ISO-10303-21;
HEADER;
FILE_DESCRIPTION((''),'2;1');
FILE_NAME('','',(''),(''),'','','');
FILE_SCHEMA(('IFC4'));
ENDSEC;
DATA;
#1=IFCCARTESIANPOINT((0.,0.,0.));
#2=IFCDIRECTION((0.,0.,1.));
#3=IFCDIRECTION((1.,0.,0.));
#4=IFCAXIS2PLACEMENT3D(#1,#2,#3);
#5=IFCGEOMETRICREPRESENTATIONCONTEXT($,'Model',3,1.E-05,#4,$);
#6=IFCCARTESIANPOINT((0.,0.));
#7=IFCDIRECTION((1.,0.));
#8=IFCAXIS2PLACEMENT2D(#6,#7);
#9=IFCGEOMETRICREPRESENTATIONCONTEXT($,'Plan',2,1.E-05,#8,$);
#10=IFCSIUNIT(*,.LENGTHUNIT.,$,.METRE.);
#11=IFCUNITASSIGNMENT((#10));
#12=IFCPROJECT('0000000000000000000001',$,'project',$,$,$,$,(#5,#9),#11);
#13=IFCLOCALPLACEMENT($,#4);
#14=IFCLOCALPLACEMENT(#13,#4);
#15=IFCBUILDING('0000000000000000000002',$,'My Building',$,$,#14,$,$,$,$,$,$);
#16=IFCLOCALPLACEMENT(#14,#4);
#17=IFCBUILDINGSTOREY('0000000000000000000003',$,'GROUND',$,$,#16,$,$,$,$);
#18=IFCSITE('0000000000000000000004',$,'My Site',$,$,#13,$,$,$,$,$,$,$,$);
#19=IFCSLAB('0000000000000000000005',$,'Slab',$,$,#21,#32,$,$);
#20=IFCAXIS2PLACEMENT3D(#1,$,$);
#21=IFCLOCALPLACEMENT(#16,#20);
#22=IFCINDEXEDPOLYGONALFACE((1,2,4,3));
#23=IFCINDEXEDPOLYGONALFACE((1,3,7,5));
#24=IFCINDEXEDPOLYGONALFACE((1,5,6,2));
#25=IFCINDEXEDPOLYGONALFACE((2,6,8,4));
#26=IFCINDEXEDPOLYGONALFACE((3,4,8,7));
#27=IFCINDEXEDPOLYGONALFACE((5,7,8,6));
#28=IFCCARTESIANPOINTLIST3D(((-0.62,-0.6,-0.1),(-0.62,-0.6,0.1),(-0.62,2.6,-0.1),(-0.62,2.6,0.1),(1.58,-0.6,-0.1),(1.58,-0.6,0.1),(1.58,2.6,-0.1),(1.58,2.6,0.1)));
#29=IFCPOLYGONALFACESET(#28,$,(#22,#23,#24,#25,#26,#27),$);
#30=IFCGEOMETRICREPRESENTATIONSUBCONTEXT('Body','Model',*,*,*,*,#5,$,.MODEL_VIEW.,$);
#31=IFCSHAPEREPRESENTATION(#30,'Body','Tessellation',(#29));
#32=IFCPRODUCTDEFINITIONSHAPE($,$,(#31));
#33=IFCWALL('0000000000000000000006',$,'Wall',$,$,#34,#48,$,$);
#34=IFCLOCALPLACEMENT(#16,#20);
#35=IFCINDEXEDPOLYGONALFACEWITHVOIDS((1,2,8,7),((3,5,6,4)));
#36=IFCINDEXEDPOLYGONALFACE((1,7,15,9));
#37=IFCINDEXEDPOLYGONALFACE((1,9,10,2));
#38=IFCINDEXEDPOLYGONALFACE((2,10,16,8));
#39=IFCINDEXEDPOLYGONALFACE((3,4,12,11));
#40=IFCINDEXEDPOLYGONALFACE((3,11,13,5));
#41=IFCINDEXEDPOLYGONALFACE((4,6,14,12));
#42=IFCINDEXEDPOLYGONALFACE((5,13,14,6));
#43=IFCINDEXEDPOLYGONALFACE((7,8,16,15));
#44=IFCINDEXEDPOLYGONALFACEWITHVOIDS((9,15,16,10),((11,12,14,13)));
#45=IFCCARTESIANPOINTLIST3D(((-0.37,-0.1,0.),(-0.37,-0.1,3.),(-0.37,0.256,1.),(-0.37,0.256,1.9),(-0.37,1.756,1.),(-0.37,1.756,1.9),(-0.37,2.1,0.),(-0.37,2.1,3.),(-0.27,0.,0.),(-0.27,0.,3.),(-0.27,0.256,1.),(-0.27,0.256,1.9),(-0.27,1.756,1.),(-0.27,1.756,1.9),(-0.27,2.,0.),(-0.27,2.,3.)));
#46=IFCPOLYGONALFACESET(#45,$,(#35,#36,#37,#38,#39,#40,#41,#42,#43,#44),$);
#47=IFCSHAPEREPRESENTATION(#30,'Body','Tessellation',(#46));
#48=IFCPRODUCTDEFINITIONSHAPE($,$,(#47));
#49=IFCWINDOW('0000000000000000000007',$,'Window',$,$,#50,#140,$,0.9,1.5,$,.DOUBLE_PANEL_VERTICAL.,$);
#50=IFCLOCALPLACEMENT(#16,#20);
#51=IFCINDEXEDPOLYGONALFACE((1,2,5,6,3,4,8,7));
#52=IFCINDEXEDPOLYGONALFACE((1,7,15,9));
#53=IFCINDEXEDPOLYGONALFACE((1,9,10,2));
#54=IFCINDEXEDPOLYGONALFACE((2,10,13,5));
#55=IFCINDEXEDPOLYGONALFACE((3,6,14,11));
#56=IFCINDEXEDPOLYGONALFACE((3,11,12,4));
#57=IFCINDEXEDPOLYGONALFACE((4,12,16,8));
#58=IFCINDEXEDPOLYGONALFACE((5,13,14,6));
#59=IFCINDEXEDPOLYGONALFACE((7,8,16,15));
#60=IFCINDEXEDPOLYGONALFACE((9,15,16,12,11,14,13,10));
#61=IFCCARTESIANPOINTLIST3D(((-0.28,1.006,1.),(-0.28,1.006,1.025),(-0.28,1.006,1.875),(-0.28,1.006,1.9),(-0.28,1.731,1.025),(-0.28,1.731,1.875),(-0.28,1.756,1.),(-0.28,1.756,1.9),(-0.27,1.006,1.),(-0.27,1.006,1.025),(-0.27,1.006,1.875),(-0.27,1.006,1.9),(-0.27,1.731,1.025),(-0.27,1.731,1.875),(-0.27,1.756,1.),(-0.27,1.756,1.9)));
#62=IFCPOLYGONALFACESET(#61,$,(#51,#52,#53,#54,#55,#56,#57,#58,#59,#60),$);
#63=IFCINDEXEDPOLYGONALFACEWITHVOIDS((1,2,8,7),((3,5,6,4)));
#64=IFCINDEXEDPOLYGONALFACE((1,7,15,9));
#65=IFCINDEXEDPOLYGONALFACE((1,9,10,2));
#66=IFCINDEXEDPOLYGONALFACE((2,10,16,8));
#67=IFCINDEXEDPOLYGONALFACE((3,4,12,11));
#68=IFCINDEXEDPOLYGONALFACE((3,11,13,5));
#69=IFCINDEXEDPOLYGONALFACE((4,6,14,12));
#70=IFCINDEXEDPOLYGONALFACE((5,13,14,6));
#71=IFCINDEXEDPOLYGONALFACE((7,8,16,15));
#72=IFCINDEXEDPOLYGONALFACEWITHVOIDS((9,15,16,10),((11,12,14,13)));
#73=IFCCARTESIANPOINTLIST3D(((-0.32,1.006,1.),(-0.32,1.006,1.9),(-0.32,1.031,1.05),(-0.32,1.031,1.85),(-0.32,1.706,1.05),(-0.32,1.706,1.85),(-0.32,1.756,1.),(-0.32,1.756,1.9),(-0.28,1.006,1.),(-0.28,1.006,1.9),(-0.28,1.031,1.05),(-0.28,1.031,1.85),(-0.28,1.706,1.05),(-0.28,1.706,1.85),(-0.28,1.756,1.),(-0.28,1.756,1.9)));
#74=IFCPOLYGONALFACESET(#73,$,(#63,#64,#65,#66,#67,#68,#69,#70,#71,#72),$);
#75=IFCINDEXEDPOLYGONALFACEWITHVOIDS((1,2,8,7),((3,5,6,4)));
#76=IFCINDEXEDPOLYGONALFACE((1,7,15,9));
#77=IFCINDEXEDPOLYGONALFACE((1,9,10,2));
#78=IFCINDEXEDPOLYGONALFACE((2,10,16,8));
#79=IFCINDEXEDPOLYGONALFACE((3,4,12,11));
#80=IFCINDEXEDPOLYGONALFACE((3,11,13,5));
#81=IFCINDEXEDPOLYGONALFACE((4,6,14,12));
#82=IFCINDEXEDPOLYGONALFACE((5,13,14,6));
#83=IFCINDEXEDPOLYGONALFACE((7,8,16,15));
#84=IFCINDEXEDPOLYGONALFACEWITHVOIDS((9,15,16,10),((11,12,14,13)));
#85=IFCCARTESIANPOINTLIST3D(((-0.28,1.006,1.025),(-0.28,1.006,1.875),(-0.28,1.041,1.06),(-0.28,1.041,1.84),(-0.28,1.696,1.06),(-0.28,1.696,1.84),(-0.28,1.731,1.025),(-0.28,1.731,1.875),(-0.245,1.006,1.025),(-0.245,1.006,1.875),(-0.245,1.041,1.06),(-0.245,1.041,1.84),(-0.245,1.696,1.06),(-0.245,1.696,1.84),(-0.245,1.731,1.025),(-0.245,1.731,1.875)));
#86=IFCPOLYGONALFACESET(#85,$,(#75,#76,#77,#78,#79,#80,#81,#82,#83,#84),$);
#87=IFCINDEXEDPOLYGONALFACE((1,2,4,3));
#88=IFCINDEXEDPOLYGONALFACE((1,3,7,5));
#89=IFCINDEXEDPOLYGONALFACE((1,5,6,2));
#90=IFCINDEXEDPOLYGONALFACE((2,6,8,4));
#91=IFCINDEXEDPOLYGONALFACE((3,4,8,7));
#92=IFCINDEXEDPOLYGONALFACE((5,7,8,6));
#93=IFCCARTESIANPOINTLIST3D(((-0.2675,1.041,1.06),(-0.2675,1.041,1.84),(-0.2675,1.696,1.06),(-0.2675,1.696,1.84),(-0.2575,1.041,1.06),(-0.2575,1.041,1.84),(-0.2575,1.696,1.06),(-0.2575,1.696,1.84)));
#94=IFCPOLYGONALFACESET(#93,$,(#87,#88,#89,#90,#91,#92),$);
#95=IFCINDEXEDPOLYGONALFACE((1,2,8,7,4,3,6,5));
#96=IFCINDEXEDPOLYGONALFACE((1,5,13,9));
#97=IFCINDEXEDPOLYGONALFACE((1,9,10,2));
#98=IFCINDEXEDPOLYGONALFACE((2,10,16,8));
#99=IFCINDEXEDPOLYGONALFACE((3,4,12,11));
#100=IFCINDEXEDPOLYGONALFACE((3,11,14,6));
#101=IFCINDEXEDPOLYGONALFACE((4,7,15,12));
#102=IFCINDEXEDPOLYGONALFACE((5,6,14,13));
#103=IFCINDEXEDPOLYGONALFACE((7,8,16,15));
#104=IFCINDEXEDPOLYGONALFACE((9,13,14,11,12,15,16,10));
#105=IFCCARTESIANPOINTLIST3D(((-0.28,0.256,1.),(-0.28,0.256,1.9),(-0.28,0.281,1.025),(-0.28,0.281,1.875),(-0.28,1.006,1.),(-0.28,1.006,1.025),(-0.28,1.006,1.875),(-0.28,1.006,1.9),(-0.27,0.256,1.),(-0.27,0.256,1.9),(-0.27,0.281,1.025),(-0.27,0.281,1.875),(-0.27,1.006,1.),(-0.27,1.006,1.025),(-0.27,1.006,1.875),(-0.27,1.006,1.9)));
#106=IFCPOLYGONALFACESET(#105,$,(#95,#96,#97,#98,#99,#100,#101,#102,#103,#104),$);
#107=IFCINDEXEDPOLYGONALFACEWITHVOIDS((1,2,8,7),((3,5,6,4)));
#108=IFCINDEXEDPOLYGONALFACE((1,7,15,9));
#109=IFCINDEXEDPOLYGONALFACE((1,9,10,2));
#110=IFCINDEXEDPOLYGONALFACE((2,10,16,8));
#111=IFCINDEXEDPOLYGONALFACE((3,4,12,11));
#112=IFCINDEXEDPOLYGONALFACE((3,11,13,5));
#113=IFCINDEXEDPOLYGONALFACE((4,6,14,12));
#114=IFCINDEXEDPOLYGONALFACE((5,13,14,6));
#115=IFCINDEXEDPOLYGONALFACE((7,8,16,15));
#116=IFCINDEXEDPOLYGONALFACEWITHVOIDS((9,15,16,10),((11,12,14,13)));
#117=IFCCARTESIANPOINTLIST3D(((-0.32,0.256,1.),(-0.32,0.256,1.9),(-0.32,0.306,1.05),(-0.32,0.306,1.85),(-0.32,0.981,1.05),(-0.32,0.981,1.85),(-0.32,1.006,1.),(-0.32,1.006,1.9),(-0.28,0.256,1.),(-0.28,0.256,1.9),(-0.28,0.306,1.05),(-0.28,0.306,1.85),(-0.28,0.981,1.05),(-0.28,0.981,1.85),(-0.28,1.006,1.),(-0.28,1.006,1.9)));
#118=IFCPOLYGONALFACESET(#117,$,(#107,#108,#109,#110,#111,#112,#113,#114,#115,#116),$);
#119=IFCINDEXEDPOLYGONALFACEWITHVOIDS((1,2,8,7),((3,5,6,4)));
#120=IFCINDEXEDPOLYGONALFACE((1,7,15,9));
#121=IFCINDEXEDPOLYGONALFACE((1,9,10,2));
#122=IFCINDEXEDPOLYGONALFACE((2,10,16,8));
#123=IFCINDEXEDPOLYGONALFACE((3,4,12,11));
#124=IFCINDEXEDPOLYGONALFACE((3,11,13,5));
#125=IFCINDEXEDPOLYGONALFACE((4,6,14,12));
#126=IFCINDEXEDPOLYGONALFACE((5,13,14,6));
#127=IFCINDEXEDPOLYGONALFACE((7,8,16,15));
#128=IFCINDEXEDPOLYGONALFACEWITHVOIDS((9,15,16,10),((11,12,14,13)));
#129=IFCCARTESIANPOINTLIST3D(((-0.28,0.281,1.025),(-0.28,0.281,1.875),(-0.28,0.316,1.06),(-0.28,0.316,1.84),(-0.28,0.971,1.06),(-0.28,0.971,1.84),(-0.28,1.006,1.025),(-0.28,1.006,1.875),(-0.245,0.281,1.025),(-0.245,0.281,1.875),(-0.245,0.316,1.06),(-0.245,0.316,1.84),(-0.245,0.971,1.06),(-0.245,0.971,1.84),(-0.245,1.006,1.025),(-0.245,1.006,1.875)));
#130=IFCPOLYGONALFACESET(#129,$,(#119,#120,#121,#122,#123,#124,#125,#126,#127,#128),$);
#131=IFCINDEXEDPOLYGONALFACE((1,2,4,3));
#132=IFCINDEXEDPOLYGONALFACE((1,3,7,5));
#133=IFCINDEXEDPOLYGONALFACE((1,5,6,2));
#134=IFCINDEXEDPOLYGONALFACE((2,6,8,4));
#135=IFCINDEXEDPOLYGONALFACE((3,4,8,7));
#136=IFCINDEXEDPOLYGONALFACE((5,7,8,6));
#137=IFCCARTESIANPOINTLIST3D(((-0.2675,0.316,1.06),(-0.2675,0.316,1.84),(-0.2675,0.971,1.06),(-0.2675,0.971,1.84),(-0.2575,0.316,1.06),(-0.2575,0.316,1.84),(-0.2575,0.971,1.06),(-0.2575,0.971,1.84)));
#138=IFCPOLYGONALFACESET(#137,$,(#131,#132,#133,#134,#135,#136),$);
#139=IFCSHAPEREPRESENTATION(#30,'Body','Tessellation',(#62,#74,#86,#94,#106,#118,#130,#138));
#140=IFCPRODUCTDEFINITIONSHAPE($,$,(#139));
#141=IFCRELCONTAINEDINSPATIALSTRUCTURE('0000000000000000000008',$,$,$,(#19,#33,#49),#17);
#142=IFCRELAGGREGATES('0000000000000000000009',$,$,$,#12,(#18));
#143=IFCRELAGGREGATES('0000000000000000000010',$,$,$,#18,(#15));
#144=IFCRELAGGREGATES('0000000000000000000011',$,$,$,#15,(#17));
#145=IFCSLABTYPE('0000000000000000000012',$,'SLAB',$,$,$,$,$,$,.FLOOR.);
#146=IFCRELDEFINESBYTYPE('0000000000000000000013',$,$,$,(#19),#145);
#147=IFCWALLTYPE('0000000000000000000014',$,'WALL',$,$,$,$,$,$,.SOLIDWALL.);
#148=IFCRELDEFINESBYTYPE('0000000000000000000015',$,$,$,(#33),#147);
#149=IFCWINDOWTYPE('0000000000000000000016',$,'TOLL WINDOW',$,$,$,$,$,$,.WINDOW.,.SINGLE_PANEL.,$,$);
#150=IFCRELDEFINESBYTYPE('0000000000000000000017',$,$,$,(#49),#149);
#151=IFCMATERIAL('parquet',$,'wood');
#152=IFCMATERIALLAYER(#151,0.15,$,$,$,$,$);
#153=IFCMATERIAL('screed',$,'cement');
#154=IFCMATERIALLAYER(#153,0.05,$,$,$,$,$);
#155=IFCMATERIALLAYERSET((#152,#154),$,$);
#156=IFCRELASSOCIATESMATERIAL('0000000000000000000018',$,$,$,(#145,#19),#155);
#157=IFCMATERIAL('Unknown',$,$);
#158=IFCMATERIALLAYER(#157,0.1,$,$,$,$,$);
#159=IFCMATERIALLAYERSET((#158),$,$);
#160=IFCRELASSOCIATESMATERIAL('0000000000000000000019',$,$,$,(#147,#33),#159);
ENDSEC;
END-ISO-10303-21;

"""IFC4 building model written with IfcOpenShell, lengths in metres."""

from ifc_helpers import new_model, entity, si_unit, frame, origin_with_axes, origin_2d_with_axis, place, context, subcontext, project, spatial, line, indexed_curve, outline, extrude, shape, source, transform, mapped, material, layer, layer_set, layer_usage, type_object, type_shapes, element, fill, save


model = new_model("IFC4")

# Units and contexts
model_context = context("Model", 3, precision=1e-05, world=origin_with_axes())
plan_context = context("Plan", 2, precision=1e-05, world=origin_2d_with_axis())
body_context_1 = subcontext(model_context, "Body", "Model", "MODEL_VIEW")
body_context_2 = subcontext(plan_context, "Body", "Plan", "PLAN_VIEW")
ifc_project = project(units=[si_unit("LENGTHUNIT", "METRE")], contexts=[model_context, plan_context])

# Site, building, storey
site_placement = place(None, origin_with_axes())
site = spatial("IfcSite", under=ifc_project, at=site_placement, Name="My Site")
building_placement = place(site_placement, origin_with_axes())
building = spatial("IfcBuilding", under=site, at=building_placement, Name="My Building")
storey_placement = place(building_placement, origin_with_axes())
storey = spatial("IfcBuildingStorey", under=building, at=storey_placement, Name="GROUND")

# Slab
ifc_material_1 = material(Name="parquet", Category="wood")
ifc_layer_1 = layer(ifc_material_1, 0.15)
ifc_material_2 = material(Name="screed", Category="cement")
ifc_layer_2 = layer(ifc_material_2, 0.05)
ifc_layer_set_1 = layer_set([ifc_layer_1, ifc_layer_2])
ifc_layer_usage_1 = layer_usage(ifc_layer_set_1, "AXIS3", "POSITIVE", -0.1)
slab_type = type_object("IfcSlabType", Name="SLAB", PredefinedType="FLOOR", material=ifc_layer_set_1)
slab_placement = place(storey_placement, frame((-0.62, 2.6, 0.0), z_axis=(0.0, 0.0, 1.0), x_axis=(1.0, 0.0, 0.0)))
element("IfcSlab", 1, at=slab_placement, inside=storey, type_object=slab_type, material=ifc_layer_usage_1, Name="Slab", context=body_context_1, shape_type="SweptSolid", body=[
    extrude(outline(indexed_curve([(0.0, 0.0), (2.2, 0.0), (2.2, -3.2), (0.0, -3.2), (0.0, 0.0)])), frame((0.0, 0.0, -0.1), z_axis=(0.0, 0.0, 1.0), x_axis=(1.0, 0.0, 0.0)), (0.0, 0.0, 1.0), 0.2),
])

# Wall, opening, window
ifc_material_3 = material(Name="Unknown")
ifc_layer_3 = layer(ifc_material_3, 0.1)
ifc_layer_set_2 = layer_set([ifc_layer_3])
ifc_layer_usage_2 = layer_usage(ifc_layer_set_2, "AXIS2", "POSITIVE", 0.0)
wall_type = type_object("IfcWallType", Name="WALL", PredefinedType="SOLIDWALL", material=ifc_layer_set_2)
wall_1_placement = place(storey_placement, frame((-0.27, 0.0, 0.0), z_axis=(0.0, 0.0, 1.0), x_axis=(0.0, 1.0, 0.0)))
wall_1 = element("IfcWall", 2, at=wall_1_placement, inside=storey, type_object=wall_type, material=ifc_layer_usage_2, Name="Wall", context=body_context_1, shape_type="SweptSolid", body=[
    extrude(outline(indexed_curve([(0.0, 0.0), (-0.1, 0.1), (2.1, 0.1), (2.0, 0.0)], segments=[line(1, 2, 3, 4, 1)])), origin_with_axes(), (0.0, 0.0, 1.0), 3.0),
])
shared_shape_1 = source(origin_with_axes(), body_context_1, "Body", "SweptSolid", [
    extrude(outline(indexed_curve([(0.0, 0.0), (1.5, 0.0), (1.5, 0.9), (0.0, 0.9)], segments=[line(1, 2, 3, 4, 1)])), frame((0.0, -0.6, 0.0), z_axis=(0.0, -1.0, 0.0), x_axis=(1.0, 0.0, 0.0)), (0.0, 0.0, -1.0), 1.2),
])
opening_1_placement = place(wall_1_placement, frame((1.756, 0.1, 1.0), z_axis=(0.0, 0.0, 1.0), x_axis=(-1.0, 0.0, 0.0)))
opening_1 = element("IfcOpeningElement", 3, at=opening_1_placement, cuts=wall_1, PredefinedType="OPENING", context=body_context_1, shape_type="MappedRepresentation", body=[
    mapped(shared_shape_1, transform((0.0, 0.0, 0.0), x_axis=(1.0, 0.0, 0.0), y_axis=(0.0, 1.0, 0.0), z_axis=(0.0, 0.0, 1.0), scale=1.0)),
])
window_type_1 = type_object("IfcWindowType", Name="TOLL WINDOW", PartitioningType="SINGLE_PANEL", PredefinedType="WINDOW")
shared_shape_2 = source(origin_with_axes(), body_context_1, "Body", "SweptSolid", [
    extrude(outline(indexed_curve([(0.75, 0.0), (0.0, 0.0), (0.0, 0.9), (0.75, 0.9), (0.75, 0.875), (0.025, 0.875), (0.025, 0.025), (0.75, 0.025)], segments=[line(1, 2, 3, 4, 5, 6, 7, 8, 1)])), frame((0.0, 0.09, 0.0), z_axis=(0.0, -1.0, 0.0), x_axis=(1.0, 0.0, 0.0)), (0.0, 0.0, -1.0), 0.01),
    extrude(outline(indexed_curve([(0.0, 0.0), (0.75, 0.0), (0.75, 0.9), (0.0, 0.9)], segments=[line(1, 2, 3, 4, 1)]), holes=[indexed_curve([(0.05, 0.05), (0.725, 0.05), (0.725, 0.85), (0.05, 0.85)], segments=[line(1, 2, 3, 4, 1)])]), frame((0.0, 0.05, 0.0), z_axis=(0.0, -1.0, 0.0), x_axis=(1.0, 0.0, 0.0)), (0.0, 0.0, -1.0), 0.04),
    extrude(outline(indexed_curve([(0.0, 0.0), (0.725, 0.0), (0.725, 0.85), (0.0, 0.85)], segments=[line(1, 2, 3, 4, 1)]), holes=[indexed_curve([(0.035, 0.035), (0.69, 0.035), (0.69, 0.815), (0.035, 0.815)], segments=[line(1, 2, 3, 4, 1)])]), frame((0.025, 0.09, 0.025), z_axis=(0.0, -1.0, 0.0), x_axis=(1.0, 0.0, 0.0)), (0.0, 0.0, -1.0), 0.035),
    extrude(outline(indexed_curve([(0.035, 0.035), (0.69, 0.035), (0.69, 0.815), (0.035, 0.815)], segments=[line(1, 2, 3, 4, 1)])), frame((0.025, 0.1025, 0.025), z_axis=(0.0, -1.0, 0.0), x_axis=(1.0, 0.0, 0.0)), (0.0, 0.0, -1.0), 0.01),
    extrude(outline(indexed_curve([(0.0, 0.9), (0.75, 0.9), (0.75, 0.0), (0.0, 0.0), (0.0, 0.025), (0.725, 0.025), (0.725, 0.875), (0.0, 0.875)], segments=[line(1, 2, 3, 4, 5, 6, 7, 8, 1)])), frame((0.75, 0.09, 0.0), z_axis=(0.0, -1.0, 0.0), x_axis=(1.0, 0.0, 0.0)), (0.0, 0.0, -1.0), 0.01),
    extrude(outline(indexed_curve([(0.0, 0.0), (0.75, 0.0), (0.75, 0.9), (0.0, 0.9)], segments=[line(1, 2, 3, 4, 1)]), holes=[indexed_curve([(0.025, 0.05), (0.7, 0.05), (0.7, 0.85), (0.025, 0.85)], segments=[line(1, 2, 3, 4, 1)])]), frame((0.75, 0.05, 0.0), z_axis=(0.0, -1.0, 0.0), x_axis=(1.0, 0.0, 0.0)), (0.0, 0.0, -1.0), 0.04),
    extrude(outline(indexed_curve([(0.0, 0.0), (0.725, 0.0), (0.725, 0.85), (0.0, 0.85)], segments=[line(1, 2, 3, 4, 1)]), holes=[indexed_curve([(0.035, 0.035), (0.69, 0.035), (0.69, 0.815), (0.035, 0.815)], segments=[line(1, 2, 3, 4, 1)])]), frame((0.75, 0.09, 0.025), z_axis=(0.0, -1.0, 0.0), x_axis=(1.0, 0.0, 0.0)), (0.0, 0.0, -1.0), 0.035),
    extrude(outline(indexed_curve([(0.035, 0.035), (0.69, 0.035), (0.69, 0.815), (0.035, 0.815)], segments=[line(1, 2, 3, 4, 1)])), frame((0.75, 0.1025, 0.025), z_axis=(0.0, -1.0, 0.0), x_axis=(1.0, 0.0, 0.0)), (0.0, 0.0, -1.0), 0.01),
])
shared_shape_3 = source(origin_with_axes(), body_context_2, "Body", "Curve2D", [
    entity("IfcIndexedPolyCurve", entity("IfcCartesianPointList2D", [[0.05, 0.05], [0.725, 0.05]])),
    entity("IfcIndexedPolyCurve", entity("IfcCartesianPointList2D", [[0.0, 0.1], [0.025, 0.1], [0.025, 0.09], [0.05, 0.09], [0.05, 0.05], [0.0, 0.05]]), [entity("IfcLineIndex", [1, 2, 3, 4, 5, 6, 1])]),
    entity("IfcIndexedPolyCurve", entity("IfcCartesianPointList2D", [[0.75, 0.1], [0.75, 0.1], [0.75, 0.09], [0.725, 0.09], [0.725, 0.05], [0.75, 0.05]])),
    entity("IfcIndexedPolyCurve", entity("IfcCartesianPointList2D", [[0.025, 0.09], [0.06, 0.09], [0.06, 0.125], [0.025, 0.125]]), [entity("IfcLineIndex", [1, 2, 3, 4, 1])]),
    entity("IfcIndexedPolyCurve", entity("IfcCartesianPointList2D", [[0.75, 0.09], [0.715, 0.09], [0.715, 0.125], [0.75, 0.125]]), [entity("IfcLineIndex", [1, 2, 3, 4, 1])]),
    entity("IfcIndexedPolyCurve", entity("IfcCartesianPointList2D", [[0.06, 0.09], [0.715, 0.09]])),
    entity("IfcIndexedPolyCurve", entity("IfcCartesianPointList2D", [[0.06, 0.125], [0.715, 0.125]])),
    entity("IfcIndexedPolyCurve", entity("IfcCartesianPointList2D", [[0.06, 0.1075], [0.715, 0.1075]])),
    entity("IfcIndexedPolyCurve", entity("IfcCartesianPointList2D", [[0.775, 0.05], [1.45, 0.05]])),
    entity("IfcIndexedPolyCurve", entity("IfcCartesianPointList2D", [[0.75, 0.1], [0.75, 0.1], [0.75, 0.09], [0.775, 0.09], [0.775, 0.05], [0.75, 0.05]])),
    entity("IfcIndexedPolyCurve", entity("IfcCartesianPointList2D", [[1.5, 0.1], [1.475, 0.1], [1.475, 0.09], [1.45, 0.09], [1.45, 0.05], [1.5, 0.05]]), [entity("IfcLineIndex", [1, 2, 3, 4, 5, 6, 1])]),
    entity("IfcIndexedPolyCurve", entity("IfcCartesianPointList2D", [[0.75, 0.09], [0.785, 0.09], [0.785, 0.125], [0.75, 0.125]]), [entity("IfcLineIndex", [1, 2, 3, 4, 1])]),
    entity("IfcIndexedPolyCurve", entity("IfcCartesianPointList2D", [[1.475, 0.09], [1.44, 0.09], [1.44, 0.125], [1.475, 0.125]]), [entity("IfcLineIndex", [1, 2, 3, 4, 1])]),
    entity("IfcIndexedPolyCurve", entity("IfcCartesianPointList2D", [[0.785, 0.09], [1.44, 0.09]])),
    entity("IfcIndexedPolyCurve", entity("IfcCartesianPointList2D", [[0.785, 0.125], [1.44, 0.125]])),
    entity("IfcIndexedPolyCurve", entity("IfcCartesianPointList2D", [[0.785, 0.1075], [1.44, 0.1075]])),
])
type_shapes(window_type_1, [shared_shape_2, shared_shape_3])
window_1_placement = place(opening_1_placement, frame((0.0, 0.0, 0.0), z_axis=(0.0, 0.0, 1.0), x_axis=(1.0, 0.0, 0.0)))
window_1 = element("IfcWindow", 4, at=window_1_placement, inside=storey, type_object=window_type_1, Name="Window", OverallHeight=0.9, OverallWidth=1.5, PartitioningType="DOUBLE_PANEL_VERTICAL", shapes=[
    shape(body_context_1, "Body", "MappedRepresentation", [mapped(shared_shape_2, transform((0.0, 0.0, 0.0), x_axis=(1.0, 0.0, 0.0), y_axis=(0.0, 1.0, 0.0), z_axis=(0.0, 0.0, 1.0), scale=1.0))]),
    shape(body_context_2, "Body", "MappedRepresentation", [mapped(shared_shape_3, transform((0.0, 0.0, 0.0), x_axis=(1.0, 0.0, 0.0), y_axis=(0.0, 1.0, 0.0), z_axis=(0.0, 0.0, 1.0), scale=1.0))]),
])
fill(opening_1, window_1)

save(model, "model.ifc")
